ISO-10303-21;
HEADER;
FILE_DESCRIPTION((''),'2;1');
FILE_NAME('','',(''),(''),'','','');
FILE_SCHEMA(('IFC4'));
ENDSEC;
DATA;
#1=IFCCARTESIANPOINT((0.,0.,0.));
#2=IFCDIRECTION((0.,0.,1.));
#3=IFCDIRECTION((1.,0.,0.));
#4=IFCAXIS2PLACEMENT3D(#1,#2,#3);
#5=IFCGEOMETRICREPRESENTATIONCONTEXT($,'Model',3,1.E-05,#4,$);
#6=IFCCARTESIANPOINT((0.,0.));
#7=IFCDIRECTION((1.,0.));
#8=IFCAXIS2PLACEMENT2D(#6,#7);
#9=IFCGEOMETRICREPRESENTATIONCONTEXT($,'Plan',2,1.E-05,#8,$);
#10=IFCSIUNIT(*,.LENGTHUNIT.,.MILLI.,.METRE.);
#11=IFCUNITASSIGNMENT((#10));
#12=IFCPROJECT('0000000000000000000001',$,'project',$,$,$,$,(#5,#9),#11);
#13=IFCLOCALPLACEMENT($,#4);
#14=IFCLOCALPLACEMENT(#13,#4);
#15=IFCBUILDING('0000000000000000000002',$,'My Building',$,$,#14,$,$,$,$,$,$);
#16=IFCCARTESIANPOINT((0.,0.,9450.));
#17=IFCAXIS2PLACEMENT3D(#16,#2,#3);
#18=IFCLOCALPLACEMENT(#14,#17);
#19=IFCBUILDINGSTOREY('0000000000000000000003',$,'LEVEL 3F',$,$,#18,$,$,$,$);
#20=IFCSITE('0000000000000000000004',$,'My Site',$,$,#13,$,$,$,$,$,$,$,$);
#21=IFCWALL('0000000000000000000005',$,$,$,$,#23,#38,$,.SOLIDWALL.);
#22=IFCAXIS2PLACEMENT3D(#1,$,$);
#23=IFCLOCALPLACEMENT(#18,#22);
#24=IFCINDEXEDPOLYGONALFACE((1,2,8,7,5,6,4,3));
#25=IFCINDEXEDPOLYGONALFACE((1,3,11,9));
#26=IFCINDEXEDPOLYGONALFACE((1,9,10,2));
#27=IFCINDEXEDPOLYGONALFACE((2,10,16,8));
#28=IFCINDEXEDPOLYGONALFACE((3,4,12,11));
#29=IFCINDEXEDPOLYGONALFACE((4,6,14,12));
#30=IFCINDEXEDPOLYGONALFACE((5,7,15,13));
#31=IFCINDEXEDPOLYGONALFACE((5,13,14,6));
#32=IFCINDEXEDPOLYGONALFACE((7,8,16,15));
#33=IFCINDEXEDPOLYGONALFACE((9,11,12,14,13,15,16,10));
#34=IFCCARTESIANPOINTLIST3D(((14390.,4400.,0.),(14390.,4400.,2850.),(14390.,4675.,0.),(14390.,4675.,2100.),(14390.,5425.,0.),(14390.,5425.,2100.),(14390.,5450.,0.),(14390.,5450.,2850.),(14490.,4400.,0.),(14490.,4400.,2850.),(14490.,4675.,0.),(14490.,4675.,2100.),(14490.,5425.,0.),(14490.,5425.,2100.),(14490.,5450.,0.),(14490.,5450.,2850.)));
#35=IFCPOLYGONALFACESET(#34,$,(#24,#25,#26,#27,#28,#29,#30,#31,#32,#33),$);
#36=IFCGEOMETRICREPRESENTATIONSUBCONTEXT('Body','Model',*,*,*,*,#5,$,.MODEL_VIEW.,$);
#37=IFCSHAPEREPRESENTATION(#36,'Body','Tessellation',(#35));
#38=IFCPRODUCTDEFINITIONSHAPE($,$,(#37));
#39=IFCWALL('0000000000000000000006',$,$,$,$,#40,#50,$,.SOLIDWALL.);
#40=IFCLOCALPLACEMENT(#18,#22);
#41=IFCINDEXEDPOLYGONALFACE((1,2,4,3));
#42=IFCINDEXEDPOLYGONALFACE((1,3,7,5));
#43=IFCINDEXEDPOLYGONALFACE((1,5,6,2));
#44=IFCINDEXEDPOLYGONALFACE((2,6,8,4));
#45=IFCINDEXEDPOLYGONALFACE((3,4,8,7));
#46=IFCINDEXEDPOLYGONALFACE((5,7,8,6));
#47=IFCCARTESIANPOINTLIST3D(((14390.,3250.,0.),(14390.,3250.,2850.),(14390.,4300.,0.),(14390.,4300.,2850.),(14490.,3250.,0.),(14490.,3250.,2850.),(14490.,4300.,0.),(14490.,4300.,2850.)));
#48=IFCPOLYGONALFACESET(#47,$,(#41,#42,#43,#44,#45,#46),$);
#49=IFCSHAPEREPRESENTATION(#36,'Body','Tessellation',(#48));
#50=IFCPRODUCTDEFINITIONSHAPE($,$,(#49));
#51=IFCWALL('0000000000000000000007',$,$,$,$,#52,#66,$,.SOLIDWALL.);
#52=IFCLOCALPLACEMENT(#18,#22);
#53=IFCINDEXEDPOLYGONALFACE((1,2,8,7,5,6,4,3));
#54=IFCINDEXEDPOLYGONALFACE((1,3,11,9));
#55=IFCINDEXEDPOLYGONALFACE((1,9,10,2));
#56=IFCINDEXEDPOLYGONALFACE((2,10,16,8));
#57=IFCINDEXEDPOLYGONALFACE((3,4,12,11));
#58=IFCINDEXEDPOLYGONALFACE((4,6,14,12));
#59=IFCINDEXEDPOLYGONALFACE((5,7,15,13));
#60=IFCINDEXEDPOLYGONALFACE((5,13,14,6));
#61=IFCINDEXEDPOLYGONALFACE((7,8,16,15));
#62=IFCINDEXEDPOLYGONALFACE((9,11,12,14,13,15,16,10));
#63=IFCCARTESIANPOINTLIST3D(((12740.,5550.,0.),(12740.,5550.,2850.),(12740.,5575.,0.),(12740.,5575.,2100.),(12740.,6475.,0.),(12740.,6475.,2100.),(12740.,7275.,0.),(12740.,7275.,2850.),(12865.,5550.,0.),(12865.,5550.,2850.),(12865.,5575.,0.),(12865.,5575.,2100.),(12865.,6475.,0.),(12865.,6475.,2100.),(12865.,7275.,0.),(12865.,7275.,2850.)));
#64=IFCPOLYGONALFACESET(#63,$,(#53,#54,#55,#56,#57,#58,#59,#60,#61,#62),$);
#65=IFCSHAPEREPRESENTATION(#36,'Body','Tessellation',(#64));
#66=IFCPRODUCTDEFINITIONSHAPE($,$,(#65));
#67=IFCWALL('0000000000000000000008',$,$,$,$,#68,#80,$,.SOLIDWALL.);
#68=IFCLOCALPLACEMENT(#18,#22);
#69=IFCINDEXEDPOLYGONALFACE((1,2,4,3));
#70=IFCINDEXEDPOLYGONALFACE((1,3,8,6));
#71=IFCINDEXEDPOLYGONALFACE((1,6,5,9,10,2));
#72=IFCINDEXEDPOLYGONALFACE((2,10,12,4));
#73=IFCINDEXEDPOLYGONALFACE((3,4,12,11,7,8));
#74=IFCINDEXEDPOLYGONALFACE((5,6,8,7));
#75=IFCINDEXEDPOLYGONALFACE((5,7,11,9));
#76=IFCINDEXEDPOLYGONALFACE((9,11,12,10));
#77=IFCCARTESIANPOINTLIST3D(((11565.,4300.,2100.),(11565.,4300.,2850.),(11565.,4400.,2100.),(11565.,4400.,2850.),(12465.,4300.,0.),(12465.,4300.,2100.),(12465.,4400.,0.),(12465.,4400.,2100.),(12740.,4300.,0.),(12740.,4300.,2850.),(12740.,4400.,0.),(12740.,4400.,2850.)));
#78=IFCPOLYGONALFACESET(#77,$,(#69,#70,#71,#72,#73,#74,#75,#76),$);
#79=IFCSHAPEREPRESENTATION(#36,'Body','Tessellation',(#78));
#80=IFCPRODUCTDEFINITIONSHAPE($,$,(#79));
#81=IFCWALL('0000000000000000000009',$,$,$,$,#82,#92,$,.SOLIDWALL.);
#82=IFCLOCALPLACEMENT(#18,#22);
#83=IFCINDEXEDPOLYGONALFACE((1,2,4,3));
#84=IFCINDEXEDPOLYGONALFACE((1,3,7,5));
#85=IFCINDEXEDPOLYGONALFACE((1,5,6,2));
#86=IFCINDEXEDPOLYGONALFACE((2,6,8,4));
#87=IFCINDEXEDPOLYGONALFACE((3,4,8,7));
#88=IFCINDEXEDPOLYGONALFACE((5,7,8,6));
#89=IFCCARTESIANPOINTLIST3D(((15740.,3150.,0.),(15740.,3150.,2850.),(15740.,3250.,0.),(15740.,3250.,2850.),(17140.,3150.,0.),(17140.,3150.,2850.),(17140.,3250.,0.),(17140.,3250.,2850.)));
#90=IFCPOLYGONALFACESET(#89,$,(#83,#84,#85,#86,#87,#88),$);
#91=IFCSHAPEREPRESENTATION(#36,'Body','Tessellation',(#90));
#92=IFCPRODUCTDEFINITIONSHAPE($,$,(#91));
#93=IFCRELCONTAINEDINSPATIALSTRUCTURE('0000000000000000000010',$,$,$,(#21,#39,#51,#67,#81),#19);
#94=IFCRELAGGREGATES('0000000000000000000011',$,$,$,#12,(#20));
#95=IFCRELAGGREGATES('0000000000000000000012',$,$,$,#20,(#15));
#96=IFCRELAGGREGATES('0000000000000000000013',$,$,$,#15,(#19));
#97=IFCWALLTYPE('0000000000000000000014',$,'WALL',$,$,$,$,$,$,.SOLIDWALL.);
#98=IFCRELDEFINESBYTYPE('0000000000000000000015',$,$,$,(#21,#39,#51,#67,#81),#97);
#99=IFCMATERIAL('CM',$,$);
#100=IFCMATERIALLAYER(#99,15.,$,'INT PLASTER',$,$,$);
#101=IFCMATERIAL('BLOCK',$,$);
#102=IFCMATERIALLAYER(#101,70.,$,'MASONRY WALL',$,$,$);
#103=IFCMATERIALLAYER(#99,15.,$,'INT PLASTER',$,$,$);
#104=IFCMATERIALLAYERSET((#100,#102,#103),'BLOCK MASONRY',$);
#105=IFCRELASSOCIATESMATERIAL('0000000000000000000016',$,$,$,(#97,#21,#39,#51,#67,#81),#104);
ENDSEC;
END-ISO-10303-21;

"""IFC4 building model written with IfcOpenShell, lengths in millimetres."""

from ifc_helpers import new_model, si_unit, frame, origin_with_axes, origin_2d_with_axis, place, context, subcontext, project, spatial, indexed_curve, outline, extrude, material, layer, layer_set, layer_usage, type_object, element, save


model = new_model("IFC4")

# Units and contexts
model_context = context("Model", 3, precision=1e-05, world=origin_with_axes())
plan_context = context("Plan", 2, precision=1e-05, world=origin_2d_with_axis())
body_context = subcontext(model_context, "Body", "Model", "MODEL_VIEW")
ifc_project = project(units=[si_unit("LENGTHUNIT", "METRE", prefix="MILLI")], contexts=[model_context, plan_context])

# Site, building, storey
site_placement = place(None, origin_with_axes())
site = spatial("IfcSite", under=ifc_project, at=site_placement, Name="My Site")
building_placement = place(site_placement, origin_with_axes())
building = spatial("IfcBuilding", under=site, at=building_placement, Name="My Building")
storey_placement = place(building_placement, frame((0.0, 0.0, 9450.0), z_axis=(0.0, 0.0, 1.0), x_axis=(1.0, 0.0, 0.0)))
storey = spatial("IfcBuildingStorey", under=building, at=storey_placement, Name="LEVEL 3F")

# Shared definitions
ifc_material_1 = material(Name="CM")
ifc_layer_1 = layer(ifc_material_1, 15.0, Name="INT PLASTER")
ifc_material_2 = material(Name="BLOCK")
ifc_layer_2 = layer(ifc_material_2, 70.0, Name="MASONRY WALL")
ifc_layer_3 = layer(ifc_material_1, 15.0, Name="INT PLASTER")
ifc_layer_set = layer_set([ifc_layer_1, ifc_layer_2, ifc_layer_3], Name="BLOCK MASONRY")
wall_type = type_object("IfcWallType", Name="WALL", PredefinedType="SOLIDWALL", material=ifc_layer_set)

# Wall, opening
ifc_layer_usage_1 = layer_usage(ifc_layer_set, "AXIS2", "POSITIVE", 0.0)
wall_1_placement = place(storey_placement, frame((14490.0, 4400.0, 0.0), z_axis=(0.0, 0.0, 1.0), x_axis=(0.0, 1.0, 0.0)))
wall_1 = element("IfcWall", 1, at=wall_1_placement, inside=storey, type_object=wall_type, material=ifc_layer_usage_1, PredefinedType="SOLIDWALL", context=body_context, shape_type="SweptSolid", body=[
    extrude(outline(indexed_curve([(0.0, 0.0), (0.0, 100.0), (1050.0, 100.0), (1050.0, 0.0), (0.0, 0.0)], self_intersect=False)), origin_with_axes(), (0.0, 0.0, 1.0), 2850.0),
])
opening_1_placement = place(wall_1_placement, frame((275.0, 0.0, 0.0), z_axis=(0.0, 0.0, 1.0), x_axis=(1.0, 0.0, 0.0)))
element("IfcOpeningElement", 2, at=opening_1_placement, cuts=wall_1, PredefinedType="OPENING", context=body_context, shape_type="SweptSolid", body=[
    extrude(outline(indexed_curve([(0.0, 0.0), (0.0, 400.0), (750.0, 400.0), (750.0, 0.0), (0.0, 0.0)], self_intersect=False)), frame((0.0, -100.0, 0.0), z_axis=(0.0, 0.0, 1.0), x_axis=(1.0, 0.0, 0.0)), (0.0, 0.0, 1.0), 2100.0),
])

# Wall
ifc_layer_usage_2 = layer_usage(ifc_layer_set, "AXIS2", "POSITIVE", 0.0)
wall_2_placement = place(storey_placement, frame((14490.0, 3250.0, 0.0), z_axis=(0.0, 0.0, 1.0), x_axis=(0.0, 1.0, 0.0)))
element("IfcWall", 3, at=wall_2_placement, inside=storey, type_object=wall_type, material=ifc_layer_usage_2, PredefinedType="SOLIDWALL", context=body_context, shape_type="SweptSolid", body=[
    extrude(outline(indexed_curve([(0.0, 0.0), (0.0, 100.0), (1050.0, 100.0), (1050.0, 0.0), (0.0, 0.0)], self_intersect=False)), origin_with_axes(), (0.0, 0.0, 1.0), 2850.0),
])

# Walls, openings
ifc_layer_usage_3 = layer_usage(ifc_layer_set, "AXIS2", "POSITIVE", 0.0)
wall_3_placement = place(storey_placement, frame((12865.0, 5550.0, 0.0), z_axis=(0.0, 0.0, 1.0), x_axis=(0.0, 1.0, 0.0)))
wall_3 = element("IfcWall", 4, at=wall_3_placement, inside=storey, type_object=wall_type, material=ifc_layer_usage_3, PredefinedType="SOLIDWALL", context=body_context, shape_type="SweptSolid", body=[
    extrude(outline(indexed_curve([(0.0, 0.0), (0.0, 125.0), (1725.0, 125.0), (1725.0, 0.0), (0.0, 0.0)], self_intersect=False)), origin_with_axes(), (0.0, 0.0, 1.0), 2850.0),
])
opening_2_placement = place(wall_3_placement, frame((925.0, 125.0, 0.0), z_axis=(0.0, 0.0, 1.0), x_axis=(-1.0, 0.0, 0.0)))
element("IfcOpeningElement", 5, at=opening_2_placement, cuts=wall_3, PredefinedType="OPENING", context=body_context, shape_type="SweptSolid", body=[
    extrude(outline(indexed_curve([(0.0, 0.0), (0.0, 400.0), (900.0, 400.0), (900.0, 0.0), (0.0, 0.0)], self_intersect=False)), frame((0.0, -100.0, 0.0), z_axis=(0.0, 0.0, 1.0), x_axis=(1.0, 0.0, 0.0)), (0.0, 0.0, 1.0), 2100.0),
])
ifc_layer_usage_4 = layer_usage(ifc_layer_set, "AXIS2", "POSITIVE", 0.0)
wall_4_placement = place(storey_placement, frame((11565.0, 4400.0, 0.0), z_axis=(0.0, 0.0, 1.0), x_axis=(0.0, -1.0, 0.0)))
wall_4 = element("IfcWall", 6, at=wall_4_placement, inside=storey, type_object=wall_type, material=ifc_layer_usage_4, PredefinedType="SOLIDWALL", context=body_context, shape_type="SweptSolid", body=[
    extrude(outline(indexed_curve([(0.0, 0.0), (0.0, 1175.0), (100.0, 1175.0), (100.0, 0.0), (0.0, 0.0)], self_intersect=False)), origin_with_axes(), (0.0, 0.0, 1.0), 2850.0),
])
opening_3_placement = place(wall_4_placement, frame((0.0, 900.0, 0.0), z_axis=(0.0, 0.0, 1.0), x_axis=(0.0, -1.0, 0.0)))
element("IfcOpeningElement", 7, at=opening_3_placement, cuts=wall_4, PredefinedType="OPENING", context=body_context, shape_type="SweptSolid", body=[
    extrude(outline(indexed_curve([(0.0, 0.0), (0.0, 400.0), (900.0, 400.0), (900.0, 0.0), (0.0, 0.0)], self_intersect=False)), frame((0.0, -100.0, 0.0), z_axis=(0.0, 0.0, 1.0), x_axis=(1.0, 0.0, 0.0)), (0.0, 0.0, 1.0), 2100.0),
])

# Wall
ifc_layer_usage_5 = layer_usage(ifc_layer_set, "AXIS2", "POSITIVE", 0.0)
wall_5_placement = place(storey_placement, frame((15740.0, 3250.0, 0.0), z_axis=(0.0, 0.0, 1.0), x_axis=(0.0, -1.0, 0.0)))
element("IfcWall", 8, at=wall_5_placement, inside=storey, type_object=wall_type, material=ifc_layer_usage_5, PredefinedType="SOLIDWALL", context=body_context, shape_type="SweptSolid", body=[
    extrude(outline(indexed_curve([(0.0, 0.0), (0.0, 1400.0), (100.0, 1400.0), (100.0, 0.0), (0.0, 0.0)], self_intersect=False)), origin_with_axes(), (0.0, 0.0, 1.0), 2850.0),
])

save(model, "model.ifc")
